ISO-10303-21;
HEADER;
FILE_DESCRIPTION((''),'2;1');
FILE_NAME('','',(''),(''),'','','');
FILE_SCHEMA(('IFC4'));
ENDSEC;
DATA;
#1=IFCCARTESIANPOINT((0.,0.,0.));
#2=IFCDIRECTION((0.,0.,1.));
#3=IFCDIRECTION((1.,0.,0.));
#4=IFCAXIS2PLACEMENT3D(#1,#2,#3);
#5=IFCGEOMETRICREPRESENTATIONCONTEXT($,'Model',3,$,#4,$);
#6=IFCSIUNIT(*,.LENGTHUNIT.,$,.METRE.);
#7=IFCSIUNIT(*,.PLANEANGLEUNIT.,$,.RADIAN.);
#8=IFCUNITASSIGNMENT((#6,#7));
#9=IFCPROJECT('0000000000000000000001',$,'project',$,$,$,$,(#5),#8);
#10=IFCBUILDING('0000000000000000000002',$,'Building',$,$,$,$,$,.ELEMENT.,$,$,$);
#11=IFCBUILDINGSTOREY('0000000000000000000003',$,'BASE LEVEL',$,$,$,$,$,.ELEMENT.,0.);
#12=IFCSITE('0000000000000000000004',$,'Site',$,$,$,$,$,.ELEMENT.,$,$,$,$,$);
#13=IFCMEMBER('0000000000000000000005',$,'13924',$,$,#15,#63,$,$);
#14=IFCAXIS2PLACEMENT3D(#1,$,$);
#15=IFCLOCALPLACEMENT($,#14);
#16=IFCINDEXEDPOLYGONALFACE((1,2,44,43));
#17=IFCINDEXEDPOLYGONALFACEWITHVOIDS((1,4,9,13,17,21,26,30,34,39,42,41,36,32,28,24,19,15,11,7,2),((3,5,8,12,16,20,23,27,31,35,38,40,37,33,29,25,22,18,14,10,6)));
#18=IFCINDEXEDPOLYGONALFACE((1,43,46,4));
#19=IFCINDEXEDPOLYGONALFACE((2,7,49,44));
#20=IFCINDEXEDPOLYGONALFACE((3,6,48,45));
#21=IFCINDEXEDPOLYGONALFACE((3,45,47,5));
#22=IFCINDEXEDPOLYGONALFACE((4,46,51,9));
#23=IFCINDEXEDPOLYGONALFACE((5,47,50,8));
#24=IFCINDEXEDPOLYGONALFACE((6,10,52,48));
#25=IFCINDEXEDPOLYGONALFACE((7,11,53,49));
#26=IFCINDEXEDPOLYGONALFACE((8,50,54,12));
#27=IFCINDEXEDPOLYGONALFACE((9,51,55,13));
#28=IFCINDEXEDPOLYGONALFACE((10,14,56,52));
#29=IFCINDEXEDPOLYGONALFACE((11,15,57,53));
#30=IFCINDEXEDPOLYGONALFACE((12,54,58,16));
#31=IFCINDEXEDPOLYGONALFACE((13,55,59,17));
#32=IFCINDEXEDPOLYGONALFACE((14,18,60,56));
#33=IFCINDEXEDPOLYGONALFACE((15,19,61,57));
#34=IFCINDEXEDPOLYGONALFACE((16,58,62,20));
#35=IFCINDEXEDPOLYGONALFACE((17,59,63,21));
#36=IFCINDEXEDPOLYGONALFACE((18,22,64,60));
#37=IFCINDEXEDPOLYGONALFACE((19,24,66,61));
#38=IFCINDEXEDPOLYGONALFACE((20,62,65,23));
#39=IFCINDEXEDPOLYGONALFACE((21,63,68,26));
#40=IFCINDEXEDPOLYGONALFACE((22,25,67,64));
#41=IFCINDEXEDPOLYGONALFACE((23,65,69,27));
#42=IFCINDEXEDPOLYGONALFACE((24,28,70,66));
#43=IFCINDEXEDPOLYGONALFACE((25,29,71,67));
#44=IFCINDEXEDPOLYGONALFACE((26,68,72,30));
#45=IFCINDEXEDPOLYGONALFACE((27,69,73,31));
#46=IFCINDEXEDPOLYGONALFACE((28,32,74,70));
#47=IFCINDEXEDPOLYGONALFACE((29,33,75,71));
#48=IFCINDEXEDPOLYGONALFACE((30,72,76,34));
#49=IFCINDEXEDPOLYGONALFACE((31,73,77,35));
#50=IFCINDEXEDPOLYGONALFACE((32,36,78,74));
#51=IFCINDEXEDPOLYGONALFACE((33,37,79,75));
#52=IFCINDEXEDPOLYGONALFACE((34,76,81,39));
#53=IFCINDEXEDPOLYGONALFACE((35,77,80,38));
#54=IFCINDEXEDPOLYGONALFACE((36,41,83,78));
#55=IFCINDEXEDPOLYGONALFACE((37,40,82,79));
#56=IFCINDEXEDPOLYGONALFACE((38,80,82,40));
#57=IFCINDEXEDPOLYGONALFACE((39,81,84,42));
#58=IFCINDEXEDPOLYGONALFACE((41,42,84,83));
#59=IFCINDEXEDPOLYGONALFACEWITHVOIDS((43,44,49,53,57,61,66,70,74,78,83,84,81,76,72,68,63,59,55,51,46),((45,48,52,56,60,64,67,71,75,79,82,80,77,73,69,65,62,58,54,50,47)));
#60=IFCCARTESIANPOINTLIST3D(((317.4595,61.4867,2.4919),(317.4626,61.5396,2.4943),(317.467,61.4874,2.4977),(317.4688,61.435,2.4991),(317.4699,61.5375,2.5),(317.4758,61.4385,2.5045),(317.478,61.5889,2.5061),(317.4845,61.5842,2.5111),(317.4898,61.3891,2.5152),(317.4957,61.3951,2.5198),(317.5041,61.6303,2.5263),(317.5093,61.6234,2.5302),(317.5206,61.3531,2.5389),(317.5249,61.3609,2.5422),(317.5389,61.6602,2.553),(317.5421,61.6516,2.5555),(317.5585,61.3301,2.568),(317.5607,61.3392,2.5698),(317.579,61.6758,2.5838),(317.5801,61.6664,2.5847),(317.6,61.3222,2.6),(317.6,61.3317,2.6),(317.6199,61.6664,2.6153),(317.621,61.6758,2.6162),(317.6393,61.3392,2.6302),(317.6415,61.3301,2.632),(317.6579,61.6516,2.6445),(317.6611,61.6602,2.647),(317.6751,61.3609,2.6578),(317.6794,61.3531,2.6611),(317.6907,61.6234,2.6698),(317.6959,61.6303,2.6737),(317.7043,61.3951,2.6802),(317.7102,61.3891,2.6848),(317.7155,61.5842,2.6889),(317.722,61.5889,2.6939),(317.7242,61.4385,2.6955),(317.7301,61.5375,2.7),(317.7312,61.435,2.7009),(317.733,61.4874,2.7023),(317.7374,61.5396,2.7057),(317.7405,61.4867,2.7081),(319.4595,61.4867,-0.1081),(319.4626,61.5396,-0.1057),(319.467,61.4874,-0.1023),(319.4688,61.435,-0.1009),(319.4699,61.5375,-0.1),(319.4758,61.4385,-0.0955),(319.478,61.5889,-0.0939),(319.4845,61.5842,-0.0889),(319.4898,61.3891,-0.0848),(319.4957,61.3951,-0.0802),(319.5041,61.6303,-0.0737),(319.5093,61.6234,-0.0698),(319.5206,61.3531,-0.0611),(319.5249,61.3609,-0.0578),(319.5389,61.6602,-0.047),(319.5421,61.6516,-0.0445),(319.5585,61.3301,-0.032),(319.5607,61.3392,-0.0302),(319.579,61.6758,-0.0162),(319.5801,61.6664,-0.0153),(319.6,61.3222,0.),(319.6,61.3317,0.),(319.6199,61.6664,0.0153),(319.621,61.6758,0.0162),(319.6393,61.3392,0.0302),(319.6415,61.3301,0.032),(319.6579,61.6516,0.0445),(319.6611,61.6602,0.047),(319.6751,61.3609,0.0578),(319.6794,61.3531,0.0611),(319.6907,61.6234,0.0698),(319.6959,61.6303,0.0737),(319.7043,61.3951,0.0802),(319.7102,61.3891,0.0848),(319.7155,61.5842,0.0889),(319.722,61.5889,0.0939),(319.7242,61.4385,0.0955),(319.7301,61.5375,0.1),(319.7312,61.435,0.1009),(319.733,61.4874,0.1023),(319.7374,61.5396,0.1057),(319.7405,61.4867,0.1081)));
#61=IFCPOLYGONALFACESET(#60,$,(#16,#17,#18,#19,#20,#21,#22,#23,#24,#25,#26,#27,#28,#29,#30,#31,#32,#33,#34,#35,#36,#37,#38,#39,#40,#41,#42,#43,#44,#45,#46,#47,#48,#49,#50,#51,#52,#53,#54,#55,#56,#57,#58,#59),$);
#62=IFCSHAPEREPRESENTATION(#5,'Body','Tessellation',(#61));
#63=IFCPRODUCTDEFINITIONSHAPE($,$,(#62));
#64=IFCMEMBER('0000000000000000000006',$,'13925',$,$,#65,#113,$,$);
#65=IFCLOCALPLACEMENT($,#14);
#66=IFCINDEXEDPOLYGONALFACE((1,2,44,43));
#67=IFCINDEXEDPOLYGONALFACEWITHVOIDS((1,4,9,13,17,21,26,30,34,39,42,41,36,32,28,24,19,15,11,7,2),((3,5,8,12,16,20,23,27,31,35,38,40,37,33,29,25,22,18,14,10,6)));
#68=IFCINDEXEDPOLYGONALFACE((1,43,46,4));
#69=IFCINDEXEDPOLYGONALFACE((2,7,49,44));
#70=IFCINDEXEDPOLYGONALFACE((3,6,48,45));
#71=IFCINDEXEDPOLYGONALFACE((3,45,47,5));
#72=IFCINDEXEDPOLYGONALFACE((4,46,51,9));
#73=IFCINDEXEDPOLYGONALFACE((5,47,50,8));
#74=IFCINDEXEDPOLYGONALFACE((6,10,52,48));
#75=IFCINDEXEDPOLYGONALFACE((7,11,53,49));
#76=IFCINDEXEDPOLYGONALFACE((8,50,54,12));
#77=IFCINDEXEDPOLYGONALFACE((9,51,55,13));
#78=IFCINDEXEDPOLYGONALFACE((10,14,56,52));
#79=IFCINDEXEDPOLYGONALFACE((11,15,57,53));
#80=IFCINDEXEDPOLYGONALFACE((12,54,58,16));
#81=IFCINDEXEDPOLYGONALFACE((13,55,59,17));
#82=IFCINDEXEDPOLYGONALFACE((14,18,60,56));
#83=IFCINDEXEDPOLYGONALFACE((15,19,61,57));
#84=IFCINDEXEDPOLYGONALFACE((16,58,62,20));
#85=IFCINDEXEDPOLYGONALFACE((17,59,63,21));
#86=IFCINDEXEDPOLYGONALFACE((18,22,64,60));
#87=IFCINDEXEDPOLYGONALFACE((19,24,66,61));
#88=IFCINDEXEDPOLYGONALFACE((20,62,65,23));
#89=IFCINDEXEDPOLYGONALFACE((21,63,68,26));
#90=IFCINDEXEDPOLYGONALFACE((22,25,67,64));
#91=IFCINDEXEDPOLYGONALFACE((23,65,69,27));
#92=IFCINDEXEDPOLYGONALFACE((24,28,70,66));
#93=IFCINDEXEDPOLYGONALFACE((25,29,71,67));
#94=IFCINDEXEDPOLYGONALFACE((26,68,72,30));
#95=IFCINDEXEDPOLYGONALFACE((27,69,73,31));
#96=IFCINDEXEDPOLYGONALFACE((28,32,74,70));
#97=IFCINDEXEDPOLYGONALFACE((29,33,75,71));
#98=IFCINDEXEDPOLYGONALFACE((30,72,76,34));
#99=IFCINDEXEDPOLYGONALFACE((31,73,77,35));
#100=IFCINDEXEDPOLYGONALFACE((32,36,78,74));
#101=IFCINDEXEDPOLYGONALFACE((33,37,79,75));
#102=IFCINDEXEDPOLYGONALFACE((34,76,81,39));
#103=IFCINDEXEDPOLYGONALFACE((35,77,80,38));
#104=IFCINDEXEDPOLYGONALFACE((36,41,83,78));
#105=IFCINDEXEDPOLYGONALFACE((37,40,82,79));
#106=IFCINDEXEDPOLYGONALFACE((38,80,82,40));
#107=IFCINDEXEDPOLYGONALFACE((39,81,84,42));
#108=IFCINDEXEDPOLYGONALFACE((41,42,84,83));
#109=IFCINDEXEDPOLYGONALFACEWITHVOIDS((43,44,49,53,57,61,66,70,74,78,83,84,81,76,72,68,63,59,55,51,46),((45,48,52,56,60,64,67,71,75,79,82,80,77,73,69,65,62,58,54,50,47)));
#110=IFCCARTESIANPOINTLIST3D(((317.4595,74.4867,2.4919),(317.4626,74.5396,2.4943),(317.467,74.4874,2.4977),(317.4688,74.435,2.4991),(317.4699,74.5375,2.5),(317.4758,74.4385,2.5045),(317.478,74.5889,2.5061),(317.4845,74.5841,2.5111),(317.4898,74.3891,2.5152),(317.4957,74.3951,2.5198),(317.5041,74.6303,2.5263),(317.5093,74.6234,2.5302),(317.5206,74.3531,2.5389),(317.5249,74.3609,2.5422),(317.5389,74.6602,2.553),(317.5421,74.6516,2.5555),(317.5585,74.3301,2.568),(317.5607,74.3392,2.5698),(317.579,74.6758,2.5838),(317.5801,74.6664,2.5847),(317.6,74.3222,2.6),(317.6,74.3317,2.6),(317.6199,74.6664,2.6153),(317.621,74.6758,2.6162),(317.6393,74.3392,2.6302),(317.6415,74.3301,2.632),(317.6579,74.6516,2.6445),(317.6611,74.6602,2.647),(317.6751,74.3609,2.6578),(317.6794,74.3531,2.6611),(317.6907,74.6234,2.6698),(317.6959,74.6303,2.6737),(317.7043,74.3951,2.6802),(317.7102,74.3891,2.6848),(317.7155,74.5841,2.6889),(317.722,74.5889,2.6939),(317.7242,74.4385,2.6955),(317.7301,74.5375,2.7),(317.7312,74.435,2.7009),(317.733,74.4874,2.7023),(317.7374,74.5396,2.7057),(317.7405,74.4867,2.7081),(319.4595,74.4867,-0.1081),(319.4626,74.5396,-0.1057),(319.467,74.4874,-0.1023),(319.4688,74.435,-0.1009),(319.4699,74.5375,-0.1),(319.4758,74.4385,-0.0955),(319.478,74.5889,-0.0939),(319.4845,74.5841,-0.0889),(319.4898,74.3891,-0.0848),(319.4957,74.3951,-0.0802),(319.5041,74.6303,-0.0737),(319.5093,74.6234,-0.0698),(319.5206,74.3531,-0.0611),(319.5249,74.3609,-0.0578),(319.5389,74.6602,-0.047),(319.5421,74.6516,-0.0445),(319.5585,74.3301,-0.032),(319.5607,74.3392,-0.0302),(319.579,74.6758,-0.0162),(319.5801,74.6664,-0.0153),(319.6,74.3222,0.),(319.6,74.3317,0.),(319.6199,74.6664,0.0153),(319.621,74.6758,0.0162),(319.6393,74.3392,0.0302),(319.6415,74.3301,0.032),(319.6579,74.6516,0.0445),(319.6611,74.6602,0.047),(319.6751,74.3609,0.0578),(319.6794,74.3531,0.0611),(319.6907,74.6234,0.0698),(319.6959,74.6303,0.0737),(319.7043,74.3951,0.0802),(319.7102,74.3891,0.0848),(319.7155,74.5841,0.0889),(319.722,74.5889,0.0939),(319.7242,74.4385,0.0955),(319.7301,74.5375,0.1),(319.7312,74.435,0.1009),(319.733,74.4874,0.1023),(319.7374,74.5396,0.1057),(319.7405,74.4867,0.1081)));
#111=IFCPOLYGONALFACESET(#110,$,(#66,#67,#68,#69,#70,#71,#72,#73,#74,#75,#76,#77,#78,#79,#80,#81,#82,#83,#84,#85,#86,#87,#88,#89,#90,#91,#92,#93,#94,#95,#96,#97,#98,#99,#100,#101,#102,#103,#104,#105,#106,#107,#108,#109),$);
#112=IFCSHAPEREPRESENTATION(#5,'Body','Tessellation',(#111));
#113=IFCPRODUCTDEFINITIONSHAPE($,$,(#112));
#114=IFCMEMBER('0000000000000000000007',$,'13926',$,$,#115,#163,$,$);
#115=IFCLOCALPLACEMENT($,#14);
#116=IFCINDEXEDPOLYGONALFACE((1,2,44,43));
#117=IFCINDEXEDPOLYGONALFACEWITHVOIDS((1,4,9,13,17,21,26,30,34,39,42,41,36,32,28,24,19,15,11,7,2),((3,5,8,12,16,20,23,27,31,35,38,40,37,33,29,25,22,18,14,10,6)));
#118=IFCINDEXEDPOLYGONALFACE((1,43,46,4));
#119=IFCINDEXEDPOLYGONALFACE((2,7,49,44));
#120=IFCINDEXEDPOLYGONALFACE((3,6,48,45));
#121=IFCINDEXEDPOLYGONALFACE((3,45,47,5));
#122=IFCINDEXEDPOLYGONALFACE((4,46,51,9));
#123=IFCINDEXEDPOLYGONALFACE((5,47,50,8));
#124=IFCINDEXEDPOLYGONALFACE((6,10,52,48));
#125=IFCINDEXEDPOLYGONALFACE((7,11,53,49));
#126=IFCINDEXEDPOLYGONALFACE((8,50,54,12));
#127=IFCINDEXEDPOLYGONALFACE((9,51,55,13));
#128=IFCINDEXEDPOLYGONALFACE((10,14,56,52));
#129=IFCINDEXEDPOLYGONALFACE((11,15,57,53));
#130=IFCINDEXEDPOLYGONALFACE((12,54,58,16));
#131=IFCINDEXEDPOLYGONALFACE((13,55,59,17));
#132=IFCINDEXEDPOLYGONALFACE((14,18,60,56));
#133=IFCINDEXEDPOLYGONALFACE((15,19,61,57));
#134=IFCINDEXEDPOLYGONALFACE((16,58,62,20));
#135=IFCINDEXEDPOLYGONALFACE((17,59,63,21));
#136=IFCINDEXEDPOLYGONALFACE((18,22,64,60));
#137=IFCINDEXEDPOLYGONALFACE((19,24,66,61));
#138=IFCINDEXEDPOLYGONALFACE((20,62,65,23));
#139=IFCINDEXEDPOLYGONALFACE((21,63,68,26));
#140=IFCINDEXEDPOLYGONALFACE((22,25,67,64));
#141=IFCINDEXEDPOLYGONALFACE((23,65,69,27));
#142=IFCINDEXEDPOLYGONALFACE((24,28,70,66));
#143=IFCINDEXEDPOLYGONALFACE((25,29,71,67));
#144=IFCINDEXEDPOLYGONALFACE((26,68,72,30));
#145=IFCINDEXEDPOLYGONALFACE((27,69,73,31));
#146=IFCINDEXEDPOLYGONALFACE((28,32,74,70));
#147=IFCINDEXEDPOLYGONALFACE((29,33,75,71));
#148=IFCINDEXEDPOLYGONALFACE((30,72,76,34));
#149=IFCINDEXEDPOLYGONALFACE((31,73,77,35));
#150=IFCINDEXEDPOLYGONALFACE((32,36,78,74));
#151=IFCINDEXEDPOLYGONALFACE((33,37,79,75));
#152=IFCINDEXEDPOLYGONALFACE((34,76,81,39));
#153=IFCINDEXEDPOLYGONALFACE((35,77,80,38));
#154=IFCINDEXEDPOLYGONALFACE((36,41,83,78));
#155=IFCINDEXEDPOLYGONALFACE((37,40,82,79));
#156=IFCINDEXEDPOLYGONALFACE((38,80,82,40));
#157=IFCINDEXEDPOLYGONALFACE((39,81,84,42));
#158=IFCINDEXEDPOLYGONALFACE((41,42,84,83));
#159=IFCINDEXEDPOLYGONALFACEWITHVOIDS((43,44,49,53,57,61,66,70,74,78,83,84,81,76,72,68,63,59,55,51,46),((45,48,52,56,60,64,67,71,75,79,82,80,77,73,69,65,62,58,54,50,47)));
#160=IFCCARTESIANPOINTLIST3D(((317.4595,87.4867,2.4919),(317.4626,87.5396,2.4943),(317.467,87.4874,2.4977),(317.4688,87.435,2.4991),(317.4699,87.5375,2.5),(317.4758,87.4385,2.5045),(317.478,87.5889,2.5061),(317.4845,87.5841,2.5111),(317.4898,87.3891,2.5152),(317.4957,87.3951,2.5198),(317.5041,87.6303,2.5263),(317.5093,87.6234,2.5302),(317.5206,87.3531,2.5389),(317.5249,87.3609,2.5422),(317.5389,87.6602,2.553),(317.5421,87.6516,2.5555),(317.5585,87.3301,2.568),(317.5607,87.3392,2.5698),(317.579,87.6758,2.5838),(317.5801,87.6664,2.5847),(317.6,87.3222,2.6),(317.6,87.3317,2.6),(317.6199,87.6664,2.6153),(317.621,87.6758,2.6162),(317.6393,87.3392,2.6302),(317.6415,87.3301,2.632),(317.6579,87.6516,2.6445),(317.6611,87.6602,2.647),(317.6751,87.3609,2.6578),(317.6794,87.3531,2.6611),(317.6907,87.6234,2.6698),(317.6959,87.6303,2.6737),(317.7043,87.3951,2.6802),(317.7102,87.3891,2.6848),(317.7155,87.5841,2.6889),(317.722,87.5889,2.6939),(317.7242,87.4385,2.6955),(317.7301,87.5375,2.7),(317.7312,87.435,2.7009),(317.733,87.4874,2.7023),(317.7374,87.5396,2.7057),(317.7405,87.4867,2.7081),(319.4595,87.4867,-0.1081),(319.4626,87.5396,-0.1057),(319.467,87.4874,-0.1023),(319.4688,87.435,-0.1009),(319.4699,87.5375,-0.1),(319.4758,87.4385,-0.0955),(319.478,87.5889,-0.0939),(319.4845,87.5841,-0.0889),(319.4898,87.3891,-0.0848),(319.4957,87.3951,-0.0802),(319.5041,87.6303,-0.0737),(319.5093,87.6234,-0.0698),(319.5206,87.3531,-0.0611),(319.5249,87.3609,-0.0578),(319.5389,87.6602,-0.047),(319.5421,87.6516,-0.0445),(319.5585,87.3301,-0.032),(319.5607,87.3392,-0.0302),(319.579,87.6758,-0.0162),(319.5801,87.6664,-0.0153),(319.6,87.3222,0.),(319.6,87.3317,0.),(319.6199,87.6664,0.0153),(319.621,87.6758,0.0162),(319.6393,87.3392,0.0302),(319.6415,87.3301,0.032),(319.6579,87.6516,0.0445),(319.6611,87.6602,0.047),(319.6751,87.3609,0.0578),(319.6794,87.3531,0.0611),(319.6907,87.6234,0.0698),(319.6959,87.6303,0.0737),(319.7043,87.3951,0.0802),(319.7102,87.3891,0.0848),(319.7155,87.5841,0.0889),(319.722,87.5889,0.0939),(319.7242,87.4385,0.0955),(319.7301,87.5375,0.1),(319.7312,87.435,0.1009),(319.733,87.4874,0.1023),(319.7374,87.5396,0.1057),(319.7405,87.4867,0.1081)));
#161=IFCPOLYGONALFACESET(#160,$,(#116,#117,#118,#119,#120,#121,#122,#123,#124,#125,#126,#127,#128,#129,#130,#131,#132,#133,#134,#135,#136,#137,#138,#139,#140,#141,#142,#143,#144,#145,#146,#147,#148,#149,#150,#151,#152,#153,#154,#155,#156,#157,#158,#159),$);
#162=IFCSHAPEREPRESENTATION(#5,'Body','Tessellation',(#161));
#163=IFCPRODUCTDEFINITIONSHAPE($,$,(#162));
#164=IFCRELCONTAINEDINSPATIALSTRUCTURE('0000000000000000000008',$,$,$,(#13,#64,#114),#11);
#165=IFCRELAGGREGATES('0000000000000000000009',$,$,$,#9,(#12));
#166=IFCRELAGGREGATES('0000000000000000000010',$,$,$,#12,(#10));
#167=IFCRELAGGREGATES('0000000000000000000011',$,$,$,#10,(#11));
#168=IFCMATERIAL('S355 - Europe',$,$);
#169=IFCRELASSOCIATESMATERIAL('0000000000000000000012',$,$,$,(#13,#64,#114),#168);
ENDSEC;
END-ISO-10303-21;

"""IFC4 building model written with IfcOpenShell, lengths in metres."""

from ifc_helpers import new_model, si_unit, frame, origin_with_axes, origin_2d_with_axis, place, context, project, spatial, hollow_circle, extrude, material, material_profile, profile_set, profile_usage, element, save


model = new_model("IFC4")

# Units and contexts
model_context = context("Model", 3, world=origin_with_axes())
ifc_project = project(units=[si_unit("LENGTHUNIT", "METRE"), si_unit("PLANEANGLEUNIT", "RADIAN")], contexts=[model_context])

# Site, building, storey
site = spatial("IfcSite", under=ifc_project, Name="Site", CompositionType="ELEMENT")
building = spatial("IfcBuilding", under=site, Name="Building", CompositionType="ELEMENT")
storey = spatial("IfcBuildingStorey", under=building, Name="BASE LEVEL", CompositionType="ELEMENT", Elevation=0.0)

# Shared definitions
ifc_material = material(Name="S355 - Europe")

# Members
ifc_material_profile_1 = material_profile(ifc_material, hollow_circle(Radius=0.1778, WallThickness=0.0095, at=origin_2d_with_axis()))
ifc_profile_set_1 = profile_set([ifc_material_profile_1])
ifc_profile_usage_1 = profile_usage(ifc_profile_set_1, cardinal=10)
member_1_placement = place(None, frame((319.6, 61.5, 0.0), z_axis=(-0.609711, 0.0, 0.792624), x_axis=(0.0, -1.0, 0.0)))
element("IfcMember", 1, at=member_1_placement, inside=storey, material=ifc_profile_usage_1, Name="13924", context=model_context, shape_type="SweptSolid", body=[
    extrude(hollow_circle(Radius=0.1778, WallThickness=0.0095, at=origin_2d_with_axis()), origin_with_axes(), (0.0, 0.0, 1.0), 3.2802),
])
ifc_material_profile_2 = material_profile(ifc_material, hollow_circle(Radius=0.1778, WallThickness=0.0095, at=origin_2d_with_axis()))
ifc_profile_set_2 = profile_set([ifc_material_profile_2])
ifc_profile_usage_2 = profile_usage(ifc_profile_set_2, cardinal=10)
member_2_placement = place(None, frame((319.6, 74.5, 0.0), z_axis=(-0.609711, 0.0, 0.792624), x_axis=(0.0, -1.0, 0.0)))
element("IfcMember", 2, at=member_2_placement, inside=storey, material=ifc_profile_usage_2, Name="13925", context=model_context, shape_type="SweptSolid", body=[
    extrude(hollow_circle(Radius=0.1778, WallThickness=0.0095, at=origin_2d_with_axis()), origin_with_axes(), (0.0, 0.0, 1.0), 3.2802),
])
ifc_material_profile_3 = material_profile(ifc_material, hollow_circle(Radius=0.1778, WallThickness=0.0095, at=origin_2d_with_axis()))
ifc_profile_set_3 = profile_set([ifc_material_profile_3])
ifc_profile_usage_3 = profile_usage(ifc_profile_set_3, cardinal=10)
member_3_placement = place(None, frame((319.6, 87.5, 0.0), z_axis=(-0.609711, 0.0, 0.792624), x_axis=(0.0, -1.0, 0.0)))
element("IfcMember", 3, at=member_3_placement, inside=storey, material=ifc_profile_usage_3, Name="13926", context=model_context, shape_type="SweptSolid", body=[
    extrude(hollow_circle(Radius=0.1778, WallThickness=0.0095, at=origin_2d_with_axis()), origin_with_axes(), (0.0, 0.0, 1.0), 3.2802),
])

save(model, "model.ifc")
